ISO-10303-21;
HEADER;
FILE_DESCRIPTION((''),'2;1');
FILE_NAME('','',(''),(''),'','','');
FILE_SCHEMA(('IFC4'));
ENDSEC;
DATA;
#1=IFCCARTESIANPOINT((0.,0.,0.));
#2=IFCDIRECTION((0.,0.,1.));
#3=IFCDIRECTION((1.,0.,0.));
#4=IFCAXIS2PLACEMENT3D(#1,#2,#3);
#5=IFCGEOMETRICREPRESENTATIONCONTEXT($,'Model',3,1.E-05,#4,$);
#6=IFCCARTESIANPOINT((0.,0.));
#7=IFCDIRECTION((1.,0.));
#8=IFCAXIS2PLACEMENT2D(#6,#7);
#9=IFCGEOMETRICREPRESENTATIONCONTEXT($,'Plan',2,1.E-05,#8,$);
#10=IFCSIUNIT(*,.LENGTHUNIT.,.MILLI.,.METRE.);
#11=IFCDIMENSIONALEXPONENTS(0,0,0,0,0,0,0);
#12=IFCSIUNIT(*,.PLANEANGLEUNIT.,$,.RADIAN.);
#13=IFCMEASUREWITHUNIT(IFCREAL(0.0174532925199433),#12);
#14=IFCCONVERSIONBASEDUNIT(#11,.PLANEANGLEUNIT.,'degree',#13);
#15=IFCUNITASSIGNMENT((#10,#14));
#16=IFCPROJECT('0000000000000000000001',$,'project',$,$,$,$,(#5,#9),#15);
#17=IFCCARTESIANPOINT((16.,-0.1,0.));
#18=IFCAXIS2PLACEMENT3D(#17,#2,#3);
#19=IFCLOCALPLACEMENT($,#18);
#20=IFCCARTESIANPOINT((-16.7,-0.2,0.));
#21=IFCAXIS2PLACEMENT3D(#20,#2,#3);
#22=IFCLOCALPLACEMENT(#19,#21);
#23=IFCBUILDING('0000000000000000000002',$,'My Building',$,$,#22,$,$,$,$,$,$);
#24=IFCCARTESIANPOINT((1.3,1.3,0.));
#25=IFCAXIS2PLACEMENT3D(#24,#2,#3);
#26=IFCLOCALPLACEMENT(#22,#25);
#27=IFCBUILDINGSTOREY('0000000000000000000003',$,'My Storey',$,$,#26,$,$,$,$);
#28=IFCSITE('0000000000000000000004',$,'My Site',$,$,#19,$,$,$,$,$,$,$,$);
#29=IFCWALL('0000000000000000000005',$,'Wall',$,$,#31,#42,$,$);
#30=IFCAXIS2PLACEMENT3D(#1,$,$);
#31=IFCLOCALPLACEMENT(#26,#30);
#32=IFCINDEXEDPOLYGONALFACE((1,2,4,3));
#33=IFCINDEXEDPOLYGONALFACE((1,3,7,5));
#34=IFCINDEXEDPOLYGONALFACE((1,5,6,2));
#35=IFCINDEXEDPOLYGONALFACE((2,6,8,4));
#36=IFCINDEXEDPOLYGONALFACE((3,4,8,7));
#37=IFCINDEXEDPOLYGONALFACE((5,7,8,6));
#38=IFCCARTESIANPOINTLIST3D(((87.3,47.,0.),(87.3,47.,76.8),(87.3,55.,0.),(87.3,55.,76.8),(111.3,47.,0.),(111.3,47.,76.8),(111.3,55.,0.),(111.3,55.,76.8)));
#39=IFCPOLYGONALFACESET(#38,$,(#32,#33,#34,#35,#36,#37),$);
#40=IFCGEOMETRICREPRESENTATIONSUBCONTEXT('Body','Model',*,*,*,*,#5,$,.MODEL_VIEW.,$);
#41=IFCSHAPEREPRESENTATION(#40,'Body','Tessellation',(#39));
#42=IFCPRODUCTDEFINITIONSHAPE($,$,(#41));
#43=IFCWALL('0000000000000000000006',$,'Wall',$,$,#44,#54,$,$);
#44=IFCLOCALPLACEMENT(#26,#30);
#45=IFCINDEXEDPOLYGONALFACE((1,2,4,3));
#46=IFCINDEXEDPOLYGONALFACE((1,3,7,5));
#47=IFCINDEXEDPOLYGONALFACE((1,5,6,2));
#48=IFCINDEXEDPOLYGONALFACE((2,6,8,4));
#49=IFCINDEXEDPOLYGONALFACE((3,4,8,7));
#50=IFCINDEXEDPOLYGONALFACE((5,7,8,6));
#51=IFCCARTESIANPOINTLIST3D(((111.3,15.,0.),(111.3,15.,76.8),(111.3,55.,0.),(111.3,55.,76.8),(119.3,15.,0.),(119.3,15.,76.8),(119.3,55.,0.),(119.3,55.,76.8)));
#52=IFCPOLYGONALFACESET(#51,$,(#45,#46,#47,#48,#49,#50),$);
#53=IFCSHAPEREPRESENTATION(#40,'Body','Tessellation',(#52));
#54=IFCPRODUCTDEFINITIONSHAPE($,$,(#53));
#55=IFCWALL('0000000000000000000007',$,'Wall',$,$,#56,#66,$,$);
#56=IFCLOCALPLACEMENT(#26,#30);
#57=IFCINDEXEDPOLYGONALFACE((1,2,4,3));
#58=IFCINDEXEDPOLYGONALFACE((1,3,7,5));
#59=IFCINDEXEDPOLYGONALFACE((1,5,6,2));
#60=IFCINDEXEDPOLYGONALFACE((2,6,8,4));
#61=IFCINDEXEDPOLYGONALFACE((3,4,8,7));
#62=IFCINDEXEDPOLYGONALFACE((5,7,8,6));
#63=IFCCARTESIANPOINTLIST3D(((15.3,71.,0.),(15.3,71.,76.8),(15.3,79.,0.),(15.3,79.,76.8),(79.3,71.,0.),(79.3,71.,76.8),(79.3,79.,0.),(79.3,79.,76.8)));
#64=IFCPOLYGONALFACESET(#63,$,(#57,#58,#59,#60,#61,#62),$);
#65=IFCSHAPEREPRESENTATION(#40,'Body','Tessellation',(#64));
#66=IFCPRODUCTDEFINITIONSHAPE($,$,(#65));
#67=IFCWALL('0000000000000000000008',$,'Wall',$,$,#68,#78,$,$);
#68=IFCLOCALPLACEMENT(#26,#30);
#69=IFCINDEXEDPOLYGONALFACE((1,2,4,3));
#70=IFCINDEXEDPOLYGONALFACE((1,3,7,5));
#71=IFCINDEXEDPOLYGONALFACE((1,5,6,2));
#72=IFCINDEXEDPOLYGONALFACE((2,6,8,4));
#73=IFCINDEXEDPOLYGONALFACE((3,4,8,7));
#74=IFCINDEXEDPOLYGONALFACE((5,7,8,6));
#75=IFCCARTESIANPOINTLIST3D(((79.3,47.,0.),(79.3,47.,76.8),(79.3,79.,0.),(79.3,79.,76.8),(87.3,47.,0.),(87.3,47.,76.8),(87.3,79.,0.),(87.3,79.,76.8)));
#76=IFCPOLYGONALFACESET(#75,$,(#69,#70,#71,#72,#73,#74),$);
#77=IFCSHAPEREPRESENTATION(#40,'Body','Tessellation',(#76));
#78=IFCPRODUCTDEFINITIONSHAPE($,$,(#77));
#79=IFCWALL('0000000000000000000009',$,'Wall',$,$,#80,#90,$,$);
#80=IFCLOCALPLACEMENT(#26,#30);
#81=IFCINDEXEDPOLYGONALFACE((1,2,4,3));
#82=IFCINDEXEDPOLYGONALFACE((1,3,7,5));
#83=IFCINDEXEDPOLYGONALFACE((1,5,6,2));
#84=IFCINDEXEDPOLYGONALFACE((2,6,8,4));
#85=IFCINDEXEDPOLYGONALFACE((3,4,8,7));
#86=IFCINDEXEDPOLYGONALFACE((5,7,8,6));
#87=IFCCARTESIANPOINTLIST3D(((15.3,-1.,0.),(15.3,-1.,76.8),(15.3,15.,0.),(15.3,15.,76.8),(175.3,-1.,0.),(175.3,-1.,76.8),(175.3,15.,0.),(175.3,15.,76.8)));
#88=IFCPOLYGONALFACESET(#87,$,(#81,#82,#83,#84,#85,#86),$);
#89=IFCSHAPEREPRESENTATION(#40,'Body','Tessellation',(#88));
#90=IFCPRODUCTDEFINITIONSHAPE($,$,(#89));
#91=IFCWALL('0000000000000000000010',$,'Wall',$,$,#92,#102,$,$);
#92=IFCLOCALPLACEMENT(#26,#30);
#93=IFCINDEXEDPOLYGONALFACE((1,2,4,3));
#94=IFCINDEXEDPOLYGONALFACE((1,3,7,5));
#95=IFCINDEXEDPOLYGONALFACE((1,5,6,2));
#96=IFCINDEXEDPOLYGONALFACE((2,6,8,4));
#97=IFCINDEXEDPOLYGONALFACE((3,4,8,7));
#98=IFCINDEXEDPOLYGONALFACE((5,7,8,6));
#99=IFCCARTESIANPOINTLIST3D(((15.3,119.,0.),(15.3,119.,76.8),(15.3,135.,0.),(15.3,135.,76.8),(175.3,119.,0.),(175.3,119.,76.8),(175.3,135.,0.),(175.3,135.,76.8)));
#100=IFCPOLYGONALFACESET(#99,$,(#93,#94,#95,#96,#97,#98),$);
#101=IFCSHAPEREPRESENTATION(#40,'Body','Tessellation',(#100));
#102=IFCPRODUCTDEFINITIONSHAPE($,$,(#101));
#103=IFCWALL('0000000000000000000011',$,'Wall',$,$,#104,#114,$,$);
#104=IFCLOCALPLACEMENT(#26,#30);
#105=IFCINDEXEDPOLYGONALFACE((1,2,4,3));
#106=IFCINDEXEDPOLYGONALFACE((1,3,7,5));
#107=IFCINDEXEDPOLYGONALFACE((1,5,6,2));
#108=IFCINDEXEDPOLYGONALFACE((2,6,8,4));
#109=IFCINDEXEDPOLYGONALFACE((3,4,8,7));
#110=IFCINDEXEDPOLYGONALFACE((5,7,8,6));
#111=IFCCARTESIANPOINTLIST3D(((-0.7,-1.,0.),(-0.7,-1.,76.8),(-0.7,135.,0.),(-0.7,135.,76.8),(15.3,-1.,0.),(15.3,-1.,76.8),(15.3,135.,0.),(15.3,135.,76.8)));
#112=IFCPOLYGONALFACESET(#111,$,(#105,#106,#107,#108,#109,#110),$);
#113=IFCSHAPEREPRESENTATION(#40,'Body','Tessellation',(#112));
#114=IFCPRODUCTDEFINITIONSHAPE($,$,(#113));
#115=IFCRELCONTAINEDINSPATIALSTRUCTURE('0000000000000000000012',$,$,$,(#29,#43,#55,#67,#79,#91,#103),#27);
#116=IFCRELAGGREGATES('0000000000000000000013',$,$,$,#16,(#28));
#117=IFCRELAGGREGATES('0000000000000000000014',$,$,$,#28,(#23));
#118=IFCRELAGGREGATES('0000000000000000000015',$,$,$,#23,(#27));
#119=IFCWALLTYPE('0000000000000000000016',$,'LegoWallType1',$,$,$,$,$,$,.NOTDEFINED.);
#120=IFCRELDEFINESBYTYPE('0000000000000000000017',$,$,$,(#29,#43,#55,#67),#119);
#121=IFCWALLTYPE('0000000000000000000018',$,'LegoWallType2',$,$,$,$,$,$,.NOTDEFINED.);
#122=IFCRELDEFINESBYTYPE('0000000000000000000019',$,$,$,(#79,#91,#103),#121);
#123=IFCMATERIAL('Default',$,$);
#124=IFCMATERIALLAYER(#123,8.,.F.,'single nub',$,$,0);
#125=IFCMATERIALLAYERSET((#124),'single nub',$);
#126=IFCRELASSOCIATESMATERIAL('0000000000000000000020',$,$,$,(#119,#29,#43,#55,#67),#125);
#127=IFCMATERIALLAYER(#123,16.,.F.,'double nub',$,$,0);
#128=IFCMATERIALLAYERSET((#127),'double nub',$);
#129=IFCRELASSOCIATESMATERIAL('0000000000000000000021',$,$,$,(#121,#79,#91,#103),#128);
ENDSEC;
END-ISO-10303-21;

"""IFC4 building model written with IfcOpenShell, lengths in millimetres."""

from ifc_helpers import new_model, entity, si_unit, converted_unit, frame, origin_with_axes, origin_2d_with_axis, place, context, subcontext, project, spatial, indexed_curve, outline, extrude, source, transform, mapped, material, layer, layer_set, layer_usage, type_object, element, save


model = new_model("IFC4")

# Units and contexts
model_context = context("Model", 3, precision=1e-05, world=origin_with_axes())
plan_context = context("Plan", 2, precision=1e-05, world=origin_2d_with_axis())
body_context = subcontext(model_context, "Body", "Model", "MODEL_VIEW")
ifc_project = project(units=[si_unit("LENGTHUNIT", "METRE", prefix="MILLI"), converted_unit("PLANEANGLEUNIT", "degree", entity("IfcReal", 0.0174532925199433), si_unit("PLANEANGLEUNIT", "RADIAN"), dimensions=[0, 0, 0, 0, 0, 0, 0])], contexts=[model_context, plan_context])

# Site, building, storey
site_placement = place(None, frame((16.0, -0.1, 0.0), z_axis=(0.0, 0.0, 1.0), x_axis=(1.0, 0.0, 0.0)))
site = spatial("IfcSite", under=ifc_project, at=site_placement, Name="My Site")
building_placement = place(site_placement, frame((-16.7, -0.2, 0.0), z_axis=(0.0, 0.0, 1.0), x_axis=(1.0, 0.0, 0.0)))
building = spatial("IfcBuilding", under=site, at=building_placement, Name="My Building")
storey_placement = place(building_placement, frame((1.3, 1.3, 0.0), z_axis=(0.0, 0.0, 1.0), x_axis=(1.0, 0.0, 0.0)))
storey = spatial("IfcBuildingStorey", under=building, at=storey_placement, Name="My Storey")

# Walls
ifc_material = material(Name="Default")
ifc_layer_1 = layer(ifc_material, 8.0, ventilated=False, Name="single nub", Priority=0)
ifc_layer_set_1 = layer_set([ifc_layer_1], Name="single nub")
ifc_layer_usage_1 = layer_usage(ifc_layer_set_1, "AXIS2", "POSITIVE", 0.0)
wall_type_1 = type_object("IfcWallType", Name="LegoWallType1", PredefinedType="NOTDEFINED", material=ifc_layer_set_1)
wall_1_placement = place(storey_placement, frame((87.3, 47.0, 0.0), z_axis=(0.0, 0.0, 1.0), x_axis=(1.0, 0.0, 0.0)))
element("IfcWall", 1, at=wall_1_placement, inside=storey, type_object=wall_type_1, material=ifc_layer_usage_1, Name="Wall", context=body_context, shape_type="SweptSolid", body=[
    extrude(outline(indexed_curve([(0.0, 0.0), (0.0, 8.0), (24.0, 8.0), (24.0, 0.0), (0.0, 0.0)], self_intersect=False)), origin_with_axes(), (0.0, 0.0, 1.0), 76.8),
])
ifc_layer_usage_2 = layer_usage(ifc_layer_set_1, "AXIS2", "POSITIVE", 0.0)
wall_2_placement = place(storey_placement, frame((119.3, 15.0, 0.0), z_axis=(0.0, 0.0, 1.0), x_axis=(0.0, 1.0, 0.0)))
element("IfcWall", 2, at=wall_2_placement, inside=storey, type_object=wall_type_1, material=ifc_layer_usage_2, Name="Wall", context=body_context, shape_type="SweptSolid", body=[
    extrude(outline(indexed_curve([(0.0, 0.0), (0.0, 8.0), (40.0, 8.0), (40.0, 0.0), (0.0, 0.0)], self_intersect=False)), origin_with_axes(), (0.0, 0.0, 1.0), 76.8),
])

# Wall, opening
ifc_layer_usage_3 = layer_usage(ifc_layer_set_1, "AXIS2", "POSITIVE", 0.0)
wall_3_placement = place(storey_placement, frame((15.3, 71.0, 0.0), z_axis=(0.0, 0.0, 1.0), x_axis=(1.0, 0.0, 0.0)))
wall_3 = element("IfcWall", 3, at=wall_3_placement, inside=storey, type_object=wall_type_1, material=ifc_layer_usage_3, Name="Wall", context=body_context, shape_type="SweptSolid", body=[
    extrude(outline(indexed_curve([(0.0, 0.0), (0.0, 8.0), (64.0, 8.0), (64.0, 0.0), (0.0, 0.0)], self_intersect=False)), origin_with_axes(), (0.0, 0.0, 1.0), 76.8),
])
shared_shape_1 = source(origin_with_axes(), body_context, "Body", "Tessellation", [])
opening_1_placement = place(wall_3_placement, frame((16.0, 0.0, 0.0), z_axis=(0.0, 0.0, 1.0), x_axis=(1.0, 0.0, 0.0)))
element("IfcOpeningElement", 4, at=opening_1_placement, cuts=wall_3, PredefinedType="OPENING", context=body_context, shape_type="MappedRepresentation", body=[
    mapped(shared_shape_1, transform((0.0, 0.0, 0.0), x_axis=(1.0, 0.0, 0.0), y_axis=(0.0, 1.0, 0.0), z_axis=(0.0, 0.0, 1.0), scale=1.0)),
])

# Walls
ifc_layer_usage_4 = layer_usage(ifc_layer_set_1, "AXIS2", "POSITIVE", 0.0)
wall_4_placement = place(storey_placement, frame((87.3, 47.0, 0.0), z_axis=(0.0, 0.0, 1.0), x_axis=(0.0, 1.0, 0.0)))
element("IfcWall", 5, at=wall_4_placement, inside=storey, type_object=wall_type_1, material=ifc_layer_usage_4, Name="Wall", context=body_context, shape_type="SweptSolid", body=[
    extrude(outline(indexed_curve([(0.0, 0.0), (0.0, 8.0), (32.0, 8.0), (32.0, 0.0), (0.0, 0.0)], self_intersect=False)), origin_with_axes(), (0.0, 0.0, 1.0), 76.8),
])
ifc_layer_2 = layer(ifc_material, 16.0, ventilated=False, Name="double nub", Priority=0)
ifc_layer_set_2 = layer_set([ifc_layer_2], Name="double nub")
ifc_layer_usage_5 = layer_usage(ifc_layer_set_2, "AXIS2", "POSITIVE", 0.0)
wall_type_2 = type_object("IfcWallType", Name="LegoWallType2", PredefinedType="NOTDEFINED", material=ifc_layer_set_2)
wall_5_placement = place(storey_placement, frame((15.3, -1.0, 0.0), z_axis=(0.0, 0.0, 1.0), x_axis=(1.0, 0.0, 0.0)))
element("IfcWall", 6, at=wall_5_placement, inside=storey, type_object=wall_type_2, material=ifc_layer_usage_5, Name="Wall", context=body_context, shape_type="SweptSolid", body=[
    extrude(outline(indexed_curve([(0.0, 0.0), (0.0, 16.0), (160.0, 16.0), (160.0, 0.0), (0.0, 0.0)], self_intersect=False)), origin_with_axes(), (0.0, 0.0, 1.0), 76.8),
])
ifc_layer_usage_6 = layer_usage(ifc_layer_set_2, "AXIS2", "POSITIVE", 0.0)
wall_6_placement = place(storey_placement, frame((15.3, 119.0, 0.0), z_axis=(0.0, 0.0, 1.0), x_axis=(1.0, 0.0, 0.0)))
element("IfcWall", 7, at=wall_6_placement, inside=storey, type_object=wall_type_2, material=ifc_layer_usage_6, Name="Wall", context=body_context, shape_type="SweptSolid", body=[
    extrude(outline(indexed_curve([(0.0, 0.0), (0.0, 16.0), (160.0, 16.0), (160.0, 0.0), (0.0, 0.0)], self_intersect=False)), origin_with_axes(), (0.0, 0.0, 1.0), 76.8),
])

# Wall, opening
ifc_layer_usage_7 = layer_usage(ifc_layer_set_2, "AXIS2", "POSITIVE", 0.0)
wall_7_placement = place(storey_placement, frame((15.3, -1.0, 0.0), z_axis=(0.0, 0.0, 1.0), x_axis=(0.0, 1.0, 0.0)))
wall_7 = element("IfcWall", 8, at=wall_7_placement, inside=storey, type_object=wall_type_2, material=ifc_layer_usage_7, Name="Wall", context=body_context, shape_type="SweptSolid", body=[
    extrude(outline(indexed_curve([(0.0, 0.0), (0.0, 16.0), (136.0, 16.0), (136.0, 0.0), (0.0, 0.0)], self_intersect=False)), origin_with_axes(), (0.0, 0.0, 1.0), 76.8),
])
opening_2_placement = place(wall_7_placement, frame((88.0, 0.0, 0.0), z_axis=(0.0, 0.0, 1.0), x_axis=(1.0, 0.0, 0.0)))
element("IfcOpeningElement", 9, at=opening_2_placement, cuts=wall_7, PredefinedType="OPENING", context=body_context, shape_type="MappedRepresentation", body=[
    mapped(shared_shape_1, transform((0.0, 0.0, 0.0), x_axis=(1.0, 0.0, 0.0), y_axis=(0.0, 1.0, 0.0), z_axis=(0.0, 0.0, 1.0), scale=1.0)),
])

save(model, "model.ifc")
